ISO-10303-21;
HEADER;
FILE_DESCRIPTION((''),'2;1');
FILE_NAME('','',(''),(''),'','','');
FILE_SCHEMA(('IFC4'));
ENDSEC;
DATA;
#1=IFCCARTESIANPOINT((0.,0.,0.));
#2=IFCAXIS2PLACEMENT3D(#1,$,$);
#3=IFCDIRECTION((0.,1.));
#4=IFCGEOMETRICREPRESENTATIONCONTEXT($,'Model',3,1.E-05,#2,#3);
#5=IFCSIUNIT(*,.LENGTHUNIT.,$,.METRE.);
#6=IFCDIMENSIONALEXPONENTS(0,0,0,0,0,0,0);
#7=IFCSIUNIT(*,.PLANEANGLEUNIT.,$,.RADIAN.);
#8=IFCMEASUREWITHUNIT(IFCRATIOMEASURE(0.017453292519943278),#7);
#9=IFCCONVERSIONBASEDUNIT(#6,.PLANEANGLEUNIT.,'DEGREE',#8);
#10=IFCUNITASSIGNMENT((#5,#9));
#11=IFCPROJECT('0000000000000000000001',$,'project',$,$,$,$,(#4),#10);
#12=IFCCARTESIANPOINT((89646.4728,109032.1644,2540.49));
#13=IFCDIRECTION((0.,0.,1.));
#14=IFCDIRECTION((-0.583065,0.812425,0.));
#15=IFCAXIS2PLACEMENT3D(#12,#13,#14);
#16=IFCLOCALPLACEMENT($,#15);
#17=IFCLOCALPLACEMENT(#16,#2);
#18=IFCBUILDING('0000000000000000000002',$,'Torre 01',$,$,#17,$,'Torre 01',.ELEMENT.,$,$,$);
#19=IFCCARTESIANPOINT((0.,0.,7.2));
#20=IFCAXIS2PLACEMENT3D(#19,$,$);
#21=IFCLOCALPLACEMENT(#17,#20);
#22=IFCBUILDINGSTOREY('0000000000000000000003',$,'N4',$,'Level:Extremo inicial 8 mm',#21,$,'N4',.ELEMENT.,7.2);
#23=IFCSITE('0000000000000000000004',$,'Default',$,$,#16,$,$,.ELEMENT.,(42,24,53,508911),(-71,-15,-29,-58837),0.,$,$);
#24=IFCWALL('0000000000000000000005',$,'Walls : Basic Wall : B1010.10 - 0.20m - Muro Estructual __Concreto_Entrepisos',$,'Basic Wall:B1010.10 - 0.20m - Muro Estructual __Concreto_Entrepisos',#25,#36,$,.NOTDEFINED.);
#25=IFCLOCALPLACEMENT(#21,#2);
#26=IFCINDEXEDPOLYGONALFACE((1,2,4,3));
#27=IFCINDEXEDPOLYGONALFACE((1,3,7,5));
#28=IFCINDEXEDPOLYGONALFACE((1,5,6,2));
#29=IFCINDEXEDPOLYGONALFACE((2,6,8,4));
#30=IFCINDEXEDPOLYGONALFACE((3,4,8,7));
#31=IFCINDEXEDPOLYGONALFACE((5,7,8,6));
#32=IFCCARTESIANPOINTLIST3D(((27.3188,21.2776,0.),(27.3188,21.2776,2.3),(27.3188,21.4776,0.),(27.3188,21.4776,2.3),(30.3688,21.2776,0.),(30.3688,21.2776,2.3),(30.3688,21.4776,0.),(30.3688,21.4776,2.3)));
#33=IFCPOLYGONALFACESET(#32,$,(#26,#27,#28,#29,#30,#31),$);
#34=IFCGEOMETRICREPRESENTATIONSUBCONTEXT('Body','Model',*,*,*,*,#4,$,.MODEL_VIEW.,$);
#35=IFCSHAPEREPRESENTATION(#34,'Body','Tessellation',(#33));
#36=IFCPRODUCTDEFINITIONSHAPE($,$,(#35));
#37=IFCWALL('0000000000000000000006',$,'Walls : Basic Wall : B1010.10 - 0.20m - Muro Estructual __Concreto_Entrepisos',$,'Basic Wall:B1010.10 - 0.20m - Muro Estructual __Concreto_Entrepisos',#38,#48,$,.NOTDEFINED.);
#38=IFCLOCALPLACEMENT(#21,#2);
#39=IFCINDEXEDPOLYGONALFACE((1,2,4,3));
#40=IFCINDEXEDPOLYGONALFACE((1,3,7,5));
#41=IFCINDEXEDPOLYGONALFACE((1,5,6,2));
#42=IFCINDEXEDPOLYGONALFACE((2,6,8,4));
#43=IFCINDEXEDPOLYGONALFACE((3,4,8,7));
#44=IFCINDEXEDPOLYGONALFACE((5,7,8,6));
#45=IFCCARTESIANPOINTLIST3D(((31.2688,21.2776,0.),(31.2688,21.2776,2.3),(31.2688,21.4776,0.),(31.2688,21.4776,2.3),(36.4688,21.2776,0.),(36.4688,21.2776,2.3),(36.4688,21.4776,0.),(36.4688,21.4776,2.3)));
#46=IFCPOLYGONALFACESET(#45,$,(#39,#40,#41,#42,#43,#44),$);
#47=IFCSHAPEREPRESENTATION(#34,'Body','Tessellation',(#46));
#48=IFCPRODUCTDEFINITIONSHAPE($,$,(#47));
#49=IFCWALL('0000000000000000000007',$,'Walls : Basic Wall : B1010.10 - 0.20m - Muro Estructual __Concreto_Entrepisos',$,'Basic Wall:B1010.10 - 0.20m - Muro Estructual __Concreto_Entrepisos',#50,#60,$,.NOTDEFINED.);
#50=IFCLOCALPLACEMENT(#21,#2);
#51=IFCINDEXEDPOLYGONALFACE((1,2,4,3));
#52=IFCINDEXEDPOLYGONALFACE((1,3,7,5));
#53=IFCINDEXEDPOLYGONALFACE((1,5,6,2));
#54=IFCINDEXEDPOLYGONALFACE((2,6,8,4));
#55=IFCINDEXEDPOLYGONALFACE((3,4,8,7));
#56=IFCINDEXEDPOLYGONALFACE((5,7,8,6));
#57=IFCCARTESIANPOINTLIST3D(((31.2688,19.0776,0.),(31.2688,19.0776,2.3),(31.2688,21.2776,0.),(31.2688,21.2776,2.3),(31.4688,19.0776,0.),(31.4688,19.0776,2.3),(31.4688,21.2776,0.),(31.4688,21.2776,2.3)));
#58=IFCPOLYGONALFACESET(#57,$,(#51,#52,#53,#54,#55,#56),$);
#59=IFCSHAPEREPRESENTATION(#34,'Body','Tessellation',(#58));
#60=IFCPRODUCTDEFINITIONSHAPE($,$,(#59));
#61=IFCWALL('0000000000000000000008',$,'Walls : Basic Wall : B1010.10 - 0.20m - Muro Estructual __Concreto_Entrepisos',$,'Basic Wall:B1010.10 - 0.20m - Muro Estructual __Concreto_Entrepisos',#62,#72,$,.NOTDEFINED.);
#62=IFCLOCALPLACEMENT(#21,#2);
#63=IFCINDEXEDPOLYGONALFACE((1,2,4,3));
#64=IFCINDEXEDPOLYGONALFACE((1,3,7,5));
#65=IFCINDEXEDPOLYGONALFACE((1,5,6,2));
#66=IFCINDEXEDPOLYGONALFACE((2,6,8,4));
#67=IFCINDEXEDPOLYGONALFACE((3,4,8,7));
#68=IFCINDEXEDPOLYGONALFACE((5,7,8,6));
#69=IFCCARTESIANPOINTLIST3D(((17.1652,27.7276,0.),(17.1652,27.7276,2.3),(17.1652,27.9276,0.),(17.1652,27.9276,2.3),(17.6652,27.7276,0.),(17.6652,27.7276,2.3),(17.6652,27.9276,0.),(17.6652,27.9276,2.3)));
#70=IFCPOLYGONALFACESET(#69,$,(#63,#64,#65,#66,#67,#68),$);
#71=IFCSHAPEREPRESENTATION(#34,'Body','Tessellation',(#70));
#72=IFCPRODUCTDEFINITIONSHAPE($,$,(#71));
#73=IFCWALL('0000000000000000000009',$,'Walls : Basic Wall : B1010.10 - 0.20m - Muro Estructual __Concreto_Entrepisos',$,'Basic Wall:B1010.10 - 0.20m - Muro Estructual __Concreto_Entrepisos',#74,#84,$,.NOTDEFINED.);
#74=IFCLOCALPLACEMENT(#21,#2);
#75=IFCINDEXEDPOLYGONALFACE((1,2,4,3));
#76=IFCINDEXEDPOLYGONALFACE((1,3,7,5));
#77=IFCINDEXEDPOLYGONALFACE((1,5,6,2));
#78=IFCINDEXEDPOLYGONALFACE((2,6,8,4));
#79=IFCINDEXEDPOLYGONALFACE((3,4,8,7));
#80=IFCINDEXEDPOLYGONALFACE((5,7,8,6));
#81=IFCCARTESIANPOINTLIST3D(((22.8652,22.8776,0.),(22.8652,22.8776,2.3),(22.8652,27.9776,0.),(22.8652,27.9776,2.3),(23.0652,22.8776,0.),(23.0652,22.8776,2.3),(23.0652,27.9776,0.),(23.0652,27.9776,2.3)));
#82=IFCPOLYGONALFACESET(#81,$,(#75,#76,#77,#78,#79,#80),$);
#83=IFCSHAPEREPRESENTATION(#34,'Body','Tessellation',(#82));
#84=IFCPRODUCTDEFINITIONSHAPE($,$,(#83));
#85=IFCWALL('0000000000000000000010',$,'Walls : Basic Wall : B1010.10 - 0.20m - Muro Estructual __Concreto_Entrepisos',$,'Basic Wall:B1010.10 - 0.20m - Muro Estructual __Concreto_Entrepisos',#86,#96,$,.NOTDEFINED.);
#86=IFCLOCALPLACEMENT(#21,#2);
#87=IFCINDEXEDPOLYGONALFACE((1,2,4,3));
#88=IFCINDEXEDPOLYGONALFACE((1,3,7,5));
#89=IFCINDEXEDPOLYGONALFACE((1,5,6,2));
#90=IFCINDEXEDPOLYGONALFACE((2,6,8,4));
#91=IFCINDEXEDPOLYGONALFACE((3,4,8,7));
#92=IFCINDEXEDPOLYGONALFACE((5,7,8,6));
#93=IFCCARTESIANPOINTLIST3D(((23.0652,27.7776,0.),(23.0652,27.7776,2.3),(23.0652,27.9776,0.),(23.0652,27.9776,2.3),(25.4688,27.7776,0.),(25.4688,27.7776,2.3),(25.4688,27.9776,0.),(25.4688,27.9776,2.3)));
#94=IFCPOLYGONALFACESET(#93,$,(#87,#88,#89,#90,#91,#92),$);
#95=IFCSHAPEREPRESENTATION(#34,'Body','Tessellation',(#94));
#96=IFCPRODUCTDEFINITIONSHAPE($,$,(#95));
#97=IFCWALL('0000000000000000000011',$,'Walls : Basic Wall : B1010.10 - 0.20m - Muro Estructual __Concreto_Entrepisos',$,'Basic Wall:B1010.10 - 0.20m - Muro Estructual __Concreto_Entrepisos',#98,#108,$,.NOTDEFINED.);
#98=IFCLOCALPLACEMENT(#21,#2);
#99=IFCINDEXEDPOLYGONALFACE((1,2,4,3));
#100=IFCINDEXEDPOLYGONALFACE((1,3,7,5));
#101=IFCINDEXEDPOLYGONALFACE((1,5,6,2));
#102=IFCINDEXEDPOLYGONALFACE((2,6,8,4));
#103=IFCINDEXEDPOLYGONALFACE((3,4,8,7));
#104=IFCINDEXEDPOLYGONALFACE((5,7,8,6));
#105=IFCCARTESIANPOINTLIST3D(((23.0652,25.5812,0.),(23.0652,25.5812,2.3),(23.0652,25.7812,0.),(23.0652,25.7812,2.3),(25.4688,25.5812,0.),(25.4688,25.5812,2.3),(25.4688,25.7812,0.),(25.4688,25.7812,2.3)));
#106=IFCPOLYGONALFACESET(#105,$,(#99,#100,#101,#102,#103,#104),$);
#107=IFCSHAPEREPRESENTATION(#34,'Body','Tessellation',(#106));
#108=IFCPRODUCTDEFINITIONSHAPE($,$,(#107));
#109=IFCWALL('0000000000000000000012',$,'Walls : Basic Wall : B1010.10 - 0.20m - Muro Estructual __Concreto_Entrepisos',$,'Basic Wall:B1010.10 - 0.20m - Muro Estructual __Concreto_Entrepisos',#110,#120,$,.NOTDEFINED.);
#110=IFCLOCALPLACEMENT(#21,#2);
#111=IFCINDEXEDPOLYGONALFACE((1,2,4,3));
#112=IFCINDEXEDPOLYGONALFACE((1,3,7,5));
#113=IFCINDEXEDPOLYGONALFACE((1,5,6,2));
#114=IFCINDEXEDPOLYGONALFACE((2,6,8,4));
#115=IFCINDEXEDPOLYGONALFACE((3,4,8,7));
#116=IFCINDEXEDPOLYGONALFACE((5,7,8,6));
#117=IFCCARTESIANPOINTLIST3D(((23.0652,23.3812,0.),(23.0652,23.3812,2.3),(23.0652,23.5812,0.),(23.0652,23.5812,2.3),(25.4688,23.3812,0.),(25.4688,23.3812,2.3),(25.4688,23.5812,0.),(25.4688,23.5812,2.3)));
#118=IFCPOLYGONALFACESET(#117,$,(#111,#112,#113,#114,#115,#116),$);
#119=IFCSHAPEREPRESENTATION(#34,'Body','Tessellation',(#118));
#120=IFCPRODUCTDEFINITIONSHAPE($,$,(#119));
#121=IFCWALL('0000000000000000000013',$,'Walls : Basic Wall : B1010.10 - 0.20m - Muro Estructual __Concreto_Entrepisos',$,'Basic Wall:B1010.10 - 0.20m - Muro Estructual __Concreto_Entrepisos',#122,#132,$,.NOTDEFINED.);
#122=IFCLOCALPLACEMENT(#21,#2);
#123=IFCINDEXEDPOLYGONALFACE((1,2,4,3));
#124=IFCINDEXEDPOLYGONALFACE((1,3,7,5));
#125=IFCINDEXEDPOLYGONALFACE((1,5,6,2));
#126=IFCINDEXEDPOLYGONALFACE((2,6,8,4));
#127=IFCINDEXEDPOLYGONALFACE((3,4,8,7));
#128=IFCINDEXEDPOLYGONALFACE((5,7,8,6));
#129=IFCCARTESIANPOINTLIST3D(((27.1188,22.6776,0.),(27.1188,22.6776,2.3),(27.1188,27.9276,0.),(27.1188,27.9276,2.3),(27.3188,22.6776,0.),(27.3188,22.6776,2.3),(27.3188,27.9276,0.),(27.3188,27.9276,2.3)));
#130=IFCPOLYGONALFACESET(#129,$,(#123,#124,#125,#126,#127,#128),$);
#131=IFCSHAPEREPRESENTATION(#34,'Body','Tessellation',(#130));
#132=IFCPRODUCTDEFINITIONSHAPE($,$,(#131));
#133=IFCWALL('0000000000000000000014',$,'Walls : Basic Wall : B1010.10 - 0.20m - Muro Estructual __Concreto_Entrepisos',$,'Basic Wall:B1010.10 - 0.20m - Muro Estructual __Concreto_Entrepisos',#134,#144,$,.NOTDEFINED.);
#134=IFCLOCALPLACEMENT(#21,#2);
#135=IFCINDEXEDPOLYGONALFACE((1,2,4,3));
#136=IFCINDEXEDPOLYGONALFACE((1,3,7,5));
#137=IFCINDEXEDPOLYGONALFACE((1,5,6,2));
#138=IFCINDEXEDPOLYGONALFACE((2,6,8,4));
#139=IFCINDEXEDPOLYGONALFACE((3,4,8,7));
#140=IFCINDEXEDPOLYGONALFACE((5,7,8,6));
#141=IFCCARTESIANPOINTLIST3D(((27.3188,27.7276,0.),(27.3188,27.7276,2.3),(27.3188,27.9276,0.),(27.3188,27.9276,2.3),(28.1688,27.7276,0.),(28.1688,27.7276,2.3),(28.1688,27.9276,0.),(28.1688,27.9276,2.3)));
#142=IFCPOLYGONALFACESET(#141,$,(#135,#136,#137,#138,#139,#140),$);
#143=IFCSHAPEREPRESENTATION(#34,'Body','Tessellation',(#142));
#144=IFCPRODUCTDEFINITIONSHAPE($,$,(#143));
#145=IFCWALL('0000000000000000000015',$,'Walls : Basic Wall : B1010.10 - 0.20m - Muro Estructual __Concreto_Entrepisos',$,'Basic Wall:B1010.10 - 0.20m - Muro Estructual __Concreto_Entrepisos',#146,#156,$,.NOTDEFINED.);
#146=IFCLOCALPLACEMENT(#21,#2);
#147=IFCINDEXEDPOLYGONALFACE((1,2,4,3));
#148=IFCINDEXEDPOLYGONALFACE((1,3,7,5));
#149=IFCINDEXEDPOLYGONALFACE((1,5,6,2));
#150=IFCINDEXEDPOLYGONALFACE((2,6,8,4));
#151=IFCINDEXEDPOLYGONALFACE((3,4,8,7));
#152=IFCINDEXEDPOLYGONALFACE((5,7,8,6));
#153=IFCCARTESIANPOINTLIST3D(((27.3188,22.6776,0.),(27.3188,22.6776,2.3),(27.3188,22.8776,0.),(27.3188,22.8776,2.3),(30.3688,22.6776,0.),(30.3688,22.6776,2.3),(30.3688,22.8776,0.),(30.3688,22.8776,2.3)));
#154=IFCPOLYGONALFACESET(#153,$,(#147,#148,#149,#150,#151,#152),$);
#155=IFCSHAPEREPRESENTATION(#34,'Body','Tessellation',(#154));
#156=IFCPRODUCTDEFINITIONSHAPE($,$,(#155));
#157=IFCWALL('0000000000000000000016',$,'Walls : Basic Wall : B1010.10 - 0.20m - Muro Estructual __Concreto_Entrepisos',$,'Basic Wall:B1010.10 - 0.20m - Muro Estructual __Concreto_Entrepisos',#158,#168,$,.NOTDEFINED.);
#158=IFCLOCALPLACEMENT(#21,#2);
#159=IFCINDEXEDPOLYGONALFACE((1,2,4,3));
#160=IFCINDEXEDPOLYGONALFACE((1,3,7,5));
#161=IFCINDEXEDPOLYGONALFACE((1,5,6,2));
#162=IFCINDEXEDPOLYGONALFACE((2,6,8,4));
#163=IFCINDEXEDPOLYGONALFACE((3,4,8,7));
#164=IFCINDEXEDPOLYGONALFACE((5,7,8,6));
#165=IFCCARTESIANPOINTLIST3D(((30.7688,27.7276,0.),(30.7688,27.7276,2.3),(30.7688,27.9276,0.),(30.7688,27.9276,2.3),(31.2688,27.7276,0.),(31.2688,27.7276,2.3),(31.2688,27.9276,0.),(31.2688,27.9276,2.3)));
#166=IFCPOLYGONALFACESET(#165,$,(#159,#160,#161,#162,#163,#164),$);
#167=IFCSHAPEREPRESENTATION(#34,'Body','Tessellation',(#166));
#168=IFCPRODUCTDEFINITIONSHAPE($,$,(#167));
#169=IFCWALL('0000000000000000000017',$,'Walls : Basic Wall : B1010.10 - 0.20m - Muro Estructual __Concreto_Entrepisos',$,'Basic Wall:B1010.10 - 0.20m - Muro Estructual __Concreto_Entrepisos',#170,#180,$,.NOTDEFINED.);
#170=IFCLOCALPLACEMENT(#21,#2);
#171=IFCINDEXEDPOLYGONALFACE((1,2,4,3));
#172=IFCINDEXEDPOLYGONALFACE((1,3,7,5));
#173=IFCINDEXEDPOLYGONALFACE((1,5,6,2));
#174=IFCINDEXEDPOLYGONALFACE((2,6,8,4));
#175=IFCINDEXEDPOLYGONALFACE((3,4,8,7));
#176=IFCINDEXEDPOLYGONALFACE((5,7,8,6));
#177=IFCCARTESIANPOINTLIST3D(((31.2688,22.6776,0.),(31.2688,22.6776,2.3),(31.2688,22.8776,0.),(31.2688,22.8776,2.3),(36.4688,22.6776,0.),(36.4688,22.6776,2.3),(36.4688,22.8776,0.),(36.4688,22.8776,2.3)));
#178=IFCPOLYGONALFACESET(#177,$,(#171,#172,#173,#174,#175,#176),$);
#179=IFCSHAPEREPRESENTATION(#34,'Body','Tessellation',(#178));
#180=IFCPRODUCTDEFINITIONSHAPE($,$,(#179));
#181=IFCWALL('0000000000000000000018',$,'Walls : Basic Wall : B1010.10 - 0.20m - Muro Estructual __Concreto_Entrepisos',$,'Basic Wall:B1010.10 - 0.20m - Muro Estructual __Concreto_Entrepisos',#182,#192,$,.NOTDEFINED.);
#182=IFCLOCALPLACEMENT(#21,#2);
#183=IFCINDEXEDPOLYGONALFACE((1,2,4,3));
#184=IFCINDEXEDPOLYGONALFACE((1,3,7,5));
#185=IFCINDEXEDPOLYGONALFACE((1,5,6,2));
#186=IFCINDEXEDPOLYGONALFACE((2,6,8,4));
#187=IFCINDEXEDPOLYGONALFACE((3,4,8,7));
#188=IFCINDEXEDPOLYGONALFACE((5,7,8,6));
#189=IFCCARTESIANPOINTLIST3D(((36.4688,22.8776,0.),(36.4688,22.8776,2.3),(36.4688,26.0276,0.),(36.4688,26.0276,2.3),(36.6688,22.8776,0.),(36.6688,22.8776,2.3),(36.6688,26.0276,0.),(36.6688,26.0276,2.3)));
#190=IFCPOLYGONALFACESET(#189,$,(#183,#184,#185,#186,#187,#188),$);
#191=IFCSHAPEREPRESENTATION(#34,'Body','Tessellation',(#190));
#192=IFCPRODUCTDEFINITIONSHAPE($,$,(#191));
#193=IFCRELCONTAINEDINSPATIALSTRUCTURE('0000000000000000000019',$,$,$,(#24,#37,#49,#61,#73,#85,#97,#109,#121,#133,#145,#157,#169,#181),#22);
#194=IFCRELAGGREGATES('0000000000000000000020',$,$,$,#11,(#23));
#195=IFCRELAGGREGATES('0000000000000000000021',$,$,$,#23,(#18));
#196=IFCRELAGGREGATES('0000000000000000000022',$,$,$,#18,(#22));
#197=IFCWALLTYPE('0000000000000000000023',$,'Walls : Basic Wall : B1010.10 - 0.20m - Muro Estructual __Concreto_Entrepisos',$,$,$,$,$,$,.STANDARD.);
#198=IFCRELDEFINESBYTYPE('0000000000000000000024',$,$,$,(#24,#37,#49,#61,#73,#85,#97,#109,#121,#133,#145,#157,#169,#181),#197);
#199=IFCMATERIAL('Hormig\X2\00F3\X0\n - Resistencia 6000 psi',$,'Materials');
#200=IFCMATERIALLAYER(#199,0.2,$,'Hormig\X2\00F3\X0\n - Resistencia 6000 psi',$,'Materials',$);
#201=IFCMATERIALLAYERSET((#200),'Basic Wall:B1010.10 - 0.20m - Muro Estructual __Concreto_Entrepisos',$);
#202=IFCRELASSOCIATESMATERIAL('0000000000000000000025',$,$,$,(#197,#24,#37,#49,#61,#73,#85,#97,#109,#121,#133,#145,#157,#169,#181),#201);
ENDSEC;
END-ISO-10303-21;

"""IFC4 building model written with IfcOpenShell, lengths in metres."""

from ifc_helpers import new_model, entity, si_unit, converted_unit, direction, frame, frame_2d, origin, place, context, subcontext, project, spatial, rectangle, extrude, material, layer, layer_set, layer_usage, type_object, element, save


model = new_model("IFC4")

# Units and contexts
model_context = context("Model", 3, precision=1e-05, world=origin(), true_north=direction((0.0, 1.0)))
body_context = subcontext(model_context, "Body", "Model", "MODEL_VIEW")
ifc_project = project(units=[si_unit("LENGTHUNIT", "METRE"), converted_unit("PLANEANGLEUNIT", "DEGREE", entity("IfcRatioMeasure", 0.017453292519943278), si_unit("PLANEANGLEUNIT", "RADIAN"), dimensions=[0, 0, 0, 0, 0, 0, 0])], contexts=[model_context])

# Site, building, storey
site_placement = place(None, frame((89646.4728, 109032.1644, 2540.49), z_axis=(0.0, 0.0, 1.0), x_axis=(-0.583065, 0.812425, 0.0)))
site = spatial("IfcSite", under=ifc_project, at=site_placement, Name="Default", CompositionType="ELEMENT", RefLatitude=(42, 24, 53, 508911), RefLongitude=(-71, -15, -29, -58837), RefElevation=0.0)
building_placement = place(site_placement, origin())
building = spatial("IfcBuilding", under=site, at=building_placement, Name="Torre 01", LongName="Torre 01", CompositionType="ELEMENT")
storey_placement = place(building_placement, frame((0.0, 0.0, 7.2)))
storey = spatial("IfcBuildingStorey", under=building, at=storey_placement, Name="N4", ObjectType="Level:Extremo inicial 8 mm", LongName="N4", CompositionType="ELEMENT", Elevation=7.2)

# Walls
ifc_material = material(Name="Hormigón - Resistencia 6000 psi", Category="Materials")
ifc_layer_1 = layer(ifc_material, 0.2, Name="Hormigón - Resistencia 6000 psi", Category="Materials")
ifc_layer_set_1 = layer_set([ifc_layer_1], Name="Basic Wall:B1010.10 - 0.20m - Muro Estructual __Concreto_Entrepisos")
ifc_layer_usage_1 = layer_usage(ifc_layer_set_1, "AXIS2", "NEGATIVE", 0.1)
wall_type_1 = type_object("IfcWallType", Name="Walls : Basic Wall : B1010.10 - 0.20m - Muro Estructual __Concreto_Entrepisos", PredefinedType="STANDARD", material=ifc_layer_set_1)
wall_1_placement = place(storey_placement, frame((27.3188, 21.3776, 0.0)))
element("IfcWall", 1, at=wall_1_placement, inside=storey, type_object=wall_type_1, material=ifc_layer_usage_1, Name="Walls : Basic Wall : B1010.10 - 0.20m - Muro Estructual __Concreto_Entrepisos", ObjectType="Basic Wall:B1010.10 - 0.20m - Muro Estructual __Concreto_Entrepisos", PredefinedType="NOTDEFINED", context=body_context, shape_type="SweptSolid", body=[
    extrude(rectangle(XDim=3.05, YDim=0.2, at=frame_2d((1.525, 0.0), x_axis=(-1.0, 0.0))), origin(), (0.0, 0.0, 1.0), 2.3),
])
ifc_layer_usage_2 = layer_usage(ifc_layer_set_1, "AXIS2", "NEGATIVE", 0.1)
wall_2_placement = place(storey_placement, frame((31.2688, 21.3776, 0.0)))
element("IfcWall", 2, at=wall_2_placement, inside=storey, type_object=wall_type_1, material=ifc_layer_usage_2, Name="Walls : Basic Wall : B1010.10 - 0.20m - Muro Estructual __Concreto_Entrepisos", ObjectType="Basic Wall:B1010.10 - 0.20m - Muro Estructual __Concreto_Entrepisos", PredefinedType="NOTDEFINED", context=body_context, shape_type="SweptSolid", body=[
    extrude(rectangle(XDim=5.2, YDim=0.2, at=frame_2d((2.6, 0.0), x_axis=(-1.0, 0.0))), origin(), (0.0, 0.0, 1.0), 2.3),
])
ifc_layer_usage_3 = layer_usage(ifc_layer_set_1, "AXIS2", "NEGATIVE", 0.1)
wall_3_placement = place(storey_placement, frame((31.3688, 21.2776, 0.0), z_axis=(0.0, 0.0, 1.0), x_axis=(0.0, -1.0, 0.0)))
element("IfcWall", 3, at=wall_3_placement, inside=storey, type_object=wall_type_1, material=ifc_layer_usage_3, Name="Walls : Basic Wall : B1010.10 - 0.20m - Muro Estructual __Concreto_Entrepisos", ObjectType="Basic Wall:B1010.10 - 0.20m - Muro Estructual __Concreto_Entrepisos", PredefinedType="NOTDEFINED", context=body_context, shape_type="SweptSolid", body=[
    extrude(rectangle(XDim=2.2, YDim=0.2, at=frame_2d((1.1, 0.0), x_axis=(-1.0, 0.0))), origin(), (0.0, 0.0, 1.0), 2.3),
])
ifc_layer_usage_4 = layer_usage(ifc_layer_set_1, "AXIS2", "POSITIVE", -0.1)
wall_4_placement = place(storey_placement, frame((17.6652, 27.8276, 0.0), z_axis=(0.0, 0.0, 1.0), x_axis=(-1.0, 0.0, 0.0)))
element("IfcWall", 4, at=wall_4_placement, inside=storey, type_object=wall_type_1, material=ifc_layer_usage_4, Name="Walls : Basic Wall : B1010.10 - 0.20m - Muro Estructual __Concreto_Entrepisos", ObjectType="Basic Wall:B1010.10 - 0.20m - Muro Estructual __Concreto_Entrepisos", PredefinedType="NOTDEFINED", context=body_context, shape_type="SweptSolid", body=[
    extrude(rectangle(XDim=0.5, YDim=0.2, at=frame_2d((0.25, 0.0), x_axis=(-1.0, 0.0))), origin(), (0.0, 0.0, 1.0), 2.3),
])
ifc_layer_usage_5 = layer_usage(ifc_layer_set_1, "AXIS2", "NEGATIVE", 0.1)
wall_5_placement = place(storey_placement, frame((22.9652, 22.8776, 0.0), z_axis=(0.0, 0.0, 1.0), x_axis=(0.0, 1.0, 0.0)))
element("IfcWall", 5, at=wall_5_placement, inside=storey, type_object=wall_type_1, material=ifc_layer_usage_5, Name="Walls : Basic Wall : B1010.10 - 0.20m - Muro Estructual __Concreto_Entrepisos", ObjectType="Basic Wall:B1010.10 - 0.20m - Muro Estructual __Concreto_Entrepisos", PredefinedType="NOTDEFINED", context=body_context, shape_type="SweptSolid", body=[
    extrude(rectangle(XDim=5.1, YDim=0.2, at=frame_2d((2.55, 0.0), x_axis=(-1.0, 0.0))), origin(), (0.0, 0.0, 1.0), 2.3),
])
ifc_layer_usage_6 = layer_usage(ifc_layer_set_1, "AXIS2", "NEGATIVE", 0.1)
wall_6_placement = place(storey_placement, frame((23.0652, 27.8776, 0.0)))
element("IfcWall", 6, at=wall_6_placement, inside=storey, type_object=wall_type_1, material=ifc_layer_usage_6, Name="Walls : Basic Wall : B1010.10 - 0.20m - Muro Estructual __Concreto_Entrepisos", ObjectType="Basic Wall:B1010.10 - 0.20m - Muro Estructual __Concreto_Entrepisos", PredefinedType="NOTDEFINED", context=body_context, shape_type="SweptSolid", body=[
    extrude(rectangle(XDim=2.4037, YDim=0.2, at=frame_2d((1.2018, 0.0), x_axis=(-1.0, 0.0))), origin(), (0.0, 0.0, 1.0), 2.3),
])
ifc_layer_usage_7 = layer_usage(ifc_layer_set_1, "AXIS2", "NEGATIVE", 0.1)
wall_7_placement = place(storey_placement, frame((23.0652, 25.6812, 0.0)))
element("IfcWall", 7, at=wall_7_placement, inside=storey, type_object=wall_type_1, material=ifc_layer_usage_7, Name="Walls : Basic Wall : B1010.10 - 0.20m - Muro Estructual __Concreto_Entrepisos", ObjectType="Basic Wall:B1010.10 - 0.20m - Muro Estructual __Concreto_Entrepisos", PredefinedType="NOTDEFINED", context=body_context, shape_type="SweptSolid", body=[
    extrude(rectangle(XDim=2.4037, YDim=0.2, at=frame_2d((1.2018, 0.0), x_axis=(-1.0, 0.0))), origin(), (0.0, 0.0, 1.0), 2.3),
])
ifc_layer_usage_8 = layer_usage(ifc_layer_set_1, "AXIS2", "NEGATIVE", 0.1)
wall_8_placement = place(storey_placement, frame((23.0652, 23.4812, 0.0)))
element("IfcWall", 8, at=wall_8_placement, inside=storey, type_object=wall_type_1, material=ifc_layer_usage_8, Name="Walls : Basic Wall : B1010.10 - 0.20m - Muro Estructual __Concreto_Entrepisos", ObjectType="Basic Wall:B1010.10 - 0.20m - Muro Estructual __Concreto_Entrepisos", PredefinedType="NOTDEFINED", context=body_context, shape_type="SweptSolid", body=[
    extrude(rectangle(XDim=2.4037, YDim=0.2, at=frame_2d((1.2018, 0.0), x_axis=(-1.0, 0.0))), origin(), (0.0, 0.0, 1.0), 2.3),
])
ifc_layer_usage_9 = layer_usage(ifc_layer_set_1, "AXIS2", "POSITIVE", -0.1)
wall_9_placement = place(storey_placement, frame((27.2188, 27.9276, 0.0), z_axis=(0.0, 0.0, 1.0), x_axis=(0.0, -1.0, 0.0)))
element("IfcWall", 9, at=wall_9_placement, inside=storey, type_object=wall_type_1, material=ifc_layer_usage_9, Name="Walls : Basic Wall : B1010.10 - 0.20m - Muro Estructual __Concreto_Entrepisos", ObjectType="Basic Wall:B1010.10 - 0.20m - Muro Estructual __Concreto_Entrepisos", PredefinedType="NOTDEFINED", context=body_context, shape_type="SweptSolid", body=[
    extrude(rectangle(XDim=5.25, YDim=0.2, at=frame_2d((2.625, 0.0), x_axis=(-1.0, 0.0))), origin(), (0.0, 0.0, 1.0), 2.3),
])
ifc_layer_usage_10 = layer_usage(ifc_layer_set_1, "AXIS2", "POSITIVE", -0.1)
wall_10_placement = place(storey_placement, frame((27.3188, 27.8276, 0.0)))
element("IfcWall", 10, at=wall_10_placement, inside=storey, type_object=wall_type_1, material=ifc_layer_usage_10, Name="Walls : Basic Wall : B1010.10 - 0.20m - Muro Estructual __Concreto_Entrepisos", ObjectType="Basic Wall:B1010.10 - 0.20m - Muro Estructual __Concreto_Entrepisos", PredefinedType="NOTDEFINED", context=body_context, shape_type="SweptSolid", body=[
    extrude(rectangle(XDim=0.85, YDim=0.2, at=frame_2d((0.425, 0.0), x_axis=(-1.0, 0.0))), origin(), (0.0, 0.0, 1.0), 2.3),
])
ifc_layer_usage_11 = layer_usage(ifc_layer_set_1, "AXIS2", "POSITIVE", -0.1)
wall_11_placement = place(storey_placement, frame((27.3188, 22.7776, 0.0)))
element("IfcWall", 11, at=wall_11_placement, inside=storey, type_object=wall_type_1, material=ifc_layer_usage_11, Name="Walls : Basic Wall : B1010.10 - 0.20m - Muro Estructual __Concreto_Entrepisos", ObjectType="Basic Wall:B1010.10 - 0.20m - Muro Estructual __Concreto_Entrepisos", PredefinedType="NOTDEFINED", context=body_context, shape_type="SweptSolid", body=[
    extrude(rectangle(XDim=3.05, YDim=0.2, at=frame_2d((1.525, 0.0), x_axis=(-1.0, 0.0))), origin(), (0.0, 0.0, 1.0), 2.3),
])
ifc_layer_usage_12 = layer_usage(ifc_layer_set_1, "AXIS2", "POSITIVE", -0.1)
wall_12_placement = place(storey_placement, frame((30.7688, 27.8276, 0.0)))
element("IfcWall", 12, at=wall_12_placement, inside=storey, type_object=wall_type_1, material=ifc_layer_usage_12, Name="Walls : Basic Wall : B1010.10 - 0.20m - Muro Estructual __Concreto_Entrepisos", ObjectType="Basic Wall:B1010.10 - 0.20m - Muro Estructual __Concreto_Entrepisos", PredefinedType="NOTDEFINED", context=body_context, shape_type="SweptSolid", body=[
    extrude(rectangle(XDim=0.5, YDim=0.2, at=frame_2d((0.25, 0.0), x_axis=(-1.0, 0.0))), origin(), (0.0, 0.0, 1.0), 2.3),
])
ifc_layer_usage_13 = layer_usage(ifc_layer_set_1, "AXIS2", "POSITIVE", -0.1)
wall_13_placement = place(storey_placement, frame((31.2688, 22.7776, 0.0)))
element("IfcWall", 13, at=wall_13_placement, inside=storey, type_object=wall_type_1, material=ifc_layer_usage_13, Name="Walls : Basic Wall : B1010.10 - 0.20m - Muro Estructual __Concreto_Entrepisos", ObjectType="Basic Wall:B1010.10 - 0.20m - Muro Estructual __Concreto_Entrepisos", PredefinedType="NOTDEFINED", context=body_context, shape_type="SweptSolid", body=[
    extrude(rectangle(XDim=5.2, YDim=0.2, at=frame_2d((2.6, 0.0), x_axis=(-1.0, 0.0))), origin(), (0.0, 0.0, 1.0), 2.3),
])
ifc_layer_usage_14 = layer_usage(ifc_layer_set_1, "AXIS2", "POSITIVE", -0.1)
wall_14_placement = place(storey_placement, frame((36.5688, 26.0276, 0.0), z_axis=(0.0, 0.0, 1.0), x_axis=(0.0, -1.0, 0.0)))
element("IfcWall", 14, at=wall_14_placement, inside=storey, type_object=wall_type_1, material=ifc_layer_usage_14, Name="Walls : Basic Wall : B1010.10 - 0.20m - Muro Estructual __Concreto_Entrepisos", ObjectType="Basic Wall:B1010.10 - 0.20m - Muro Estructual __Concreto_Entrepisos", PredefinedType="NOTDEFINED", context=body_context, shape_type="SweptSolid", body=[
    extrude(rectangle(XDim=3.15, YDim=0.2, at=frame_2d((1.575, 0.0), x_axis=(-1.0, 0.0))), origin(), (0.0, 0.0, 1.0), 2.3),
])

save(model, "model.ifc")
